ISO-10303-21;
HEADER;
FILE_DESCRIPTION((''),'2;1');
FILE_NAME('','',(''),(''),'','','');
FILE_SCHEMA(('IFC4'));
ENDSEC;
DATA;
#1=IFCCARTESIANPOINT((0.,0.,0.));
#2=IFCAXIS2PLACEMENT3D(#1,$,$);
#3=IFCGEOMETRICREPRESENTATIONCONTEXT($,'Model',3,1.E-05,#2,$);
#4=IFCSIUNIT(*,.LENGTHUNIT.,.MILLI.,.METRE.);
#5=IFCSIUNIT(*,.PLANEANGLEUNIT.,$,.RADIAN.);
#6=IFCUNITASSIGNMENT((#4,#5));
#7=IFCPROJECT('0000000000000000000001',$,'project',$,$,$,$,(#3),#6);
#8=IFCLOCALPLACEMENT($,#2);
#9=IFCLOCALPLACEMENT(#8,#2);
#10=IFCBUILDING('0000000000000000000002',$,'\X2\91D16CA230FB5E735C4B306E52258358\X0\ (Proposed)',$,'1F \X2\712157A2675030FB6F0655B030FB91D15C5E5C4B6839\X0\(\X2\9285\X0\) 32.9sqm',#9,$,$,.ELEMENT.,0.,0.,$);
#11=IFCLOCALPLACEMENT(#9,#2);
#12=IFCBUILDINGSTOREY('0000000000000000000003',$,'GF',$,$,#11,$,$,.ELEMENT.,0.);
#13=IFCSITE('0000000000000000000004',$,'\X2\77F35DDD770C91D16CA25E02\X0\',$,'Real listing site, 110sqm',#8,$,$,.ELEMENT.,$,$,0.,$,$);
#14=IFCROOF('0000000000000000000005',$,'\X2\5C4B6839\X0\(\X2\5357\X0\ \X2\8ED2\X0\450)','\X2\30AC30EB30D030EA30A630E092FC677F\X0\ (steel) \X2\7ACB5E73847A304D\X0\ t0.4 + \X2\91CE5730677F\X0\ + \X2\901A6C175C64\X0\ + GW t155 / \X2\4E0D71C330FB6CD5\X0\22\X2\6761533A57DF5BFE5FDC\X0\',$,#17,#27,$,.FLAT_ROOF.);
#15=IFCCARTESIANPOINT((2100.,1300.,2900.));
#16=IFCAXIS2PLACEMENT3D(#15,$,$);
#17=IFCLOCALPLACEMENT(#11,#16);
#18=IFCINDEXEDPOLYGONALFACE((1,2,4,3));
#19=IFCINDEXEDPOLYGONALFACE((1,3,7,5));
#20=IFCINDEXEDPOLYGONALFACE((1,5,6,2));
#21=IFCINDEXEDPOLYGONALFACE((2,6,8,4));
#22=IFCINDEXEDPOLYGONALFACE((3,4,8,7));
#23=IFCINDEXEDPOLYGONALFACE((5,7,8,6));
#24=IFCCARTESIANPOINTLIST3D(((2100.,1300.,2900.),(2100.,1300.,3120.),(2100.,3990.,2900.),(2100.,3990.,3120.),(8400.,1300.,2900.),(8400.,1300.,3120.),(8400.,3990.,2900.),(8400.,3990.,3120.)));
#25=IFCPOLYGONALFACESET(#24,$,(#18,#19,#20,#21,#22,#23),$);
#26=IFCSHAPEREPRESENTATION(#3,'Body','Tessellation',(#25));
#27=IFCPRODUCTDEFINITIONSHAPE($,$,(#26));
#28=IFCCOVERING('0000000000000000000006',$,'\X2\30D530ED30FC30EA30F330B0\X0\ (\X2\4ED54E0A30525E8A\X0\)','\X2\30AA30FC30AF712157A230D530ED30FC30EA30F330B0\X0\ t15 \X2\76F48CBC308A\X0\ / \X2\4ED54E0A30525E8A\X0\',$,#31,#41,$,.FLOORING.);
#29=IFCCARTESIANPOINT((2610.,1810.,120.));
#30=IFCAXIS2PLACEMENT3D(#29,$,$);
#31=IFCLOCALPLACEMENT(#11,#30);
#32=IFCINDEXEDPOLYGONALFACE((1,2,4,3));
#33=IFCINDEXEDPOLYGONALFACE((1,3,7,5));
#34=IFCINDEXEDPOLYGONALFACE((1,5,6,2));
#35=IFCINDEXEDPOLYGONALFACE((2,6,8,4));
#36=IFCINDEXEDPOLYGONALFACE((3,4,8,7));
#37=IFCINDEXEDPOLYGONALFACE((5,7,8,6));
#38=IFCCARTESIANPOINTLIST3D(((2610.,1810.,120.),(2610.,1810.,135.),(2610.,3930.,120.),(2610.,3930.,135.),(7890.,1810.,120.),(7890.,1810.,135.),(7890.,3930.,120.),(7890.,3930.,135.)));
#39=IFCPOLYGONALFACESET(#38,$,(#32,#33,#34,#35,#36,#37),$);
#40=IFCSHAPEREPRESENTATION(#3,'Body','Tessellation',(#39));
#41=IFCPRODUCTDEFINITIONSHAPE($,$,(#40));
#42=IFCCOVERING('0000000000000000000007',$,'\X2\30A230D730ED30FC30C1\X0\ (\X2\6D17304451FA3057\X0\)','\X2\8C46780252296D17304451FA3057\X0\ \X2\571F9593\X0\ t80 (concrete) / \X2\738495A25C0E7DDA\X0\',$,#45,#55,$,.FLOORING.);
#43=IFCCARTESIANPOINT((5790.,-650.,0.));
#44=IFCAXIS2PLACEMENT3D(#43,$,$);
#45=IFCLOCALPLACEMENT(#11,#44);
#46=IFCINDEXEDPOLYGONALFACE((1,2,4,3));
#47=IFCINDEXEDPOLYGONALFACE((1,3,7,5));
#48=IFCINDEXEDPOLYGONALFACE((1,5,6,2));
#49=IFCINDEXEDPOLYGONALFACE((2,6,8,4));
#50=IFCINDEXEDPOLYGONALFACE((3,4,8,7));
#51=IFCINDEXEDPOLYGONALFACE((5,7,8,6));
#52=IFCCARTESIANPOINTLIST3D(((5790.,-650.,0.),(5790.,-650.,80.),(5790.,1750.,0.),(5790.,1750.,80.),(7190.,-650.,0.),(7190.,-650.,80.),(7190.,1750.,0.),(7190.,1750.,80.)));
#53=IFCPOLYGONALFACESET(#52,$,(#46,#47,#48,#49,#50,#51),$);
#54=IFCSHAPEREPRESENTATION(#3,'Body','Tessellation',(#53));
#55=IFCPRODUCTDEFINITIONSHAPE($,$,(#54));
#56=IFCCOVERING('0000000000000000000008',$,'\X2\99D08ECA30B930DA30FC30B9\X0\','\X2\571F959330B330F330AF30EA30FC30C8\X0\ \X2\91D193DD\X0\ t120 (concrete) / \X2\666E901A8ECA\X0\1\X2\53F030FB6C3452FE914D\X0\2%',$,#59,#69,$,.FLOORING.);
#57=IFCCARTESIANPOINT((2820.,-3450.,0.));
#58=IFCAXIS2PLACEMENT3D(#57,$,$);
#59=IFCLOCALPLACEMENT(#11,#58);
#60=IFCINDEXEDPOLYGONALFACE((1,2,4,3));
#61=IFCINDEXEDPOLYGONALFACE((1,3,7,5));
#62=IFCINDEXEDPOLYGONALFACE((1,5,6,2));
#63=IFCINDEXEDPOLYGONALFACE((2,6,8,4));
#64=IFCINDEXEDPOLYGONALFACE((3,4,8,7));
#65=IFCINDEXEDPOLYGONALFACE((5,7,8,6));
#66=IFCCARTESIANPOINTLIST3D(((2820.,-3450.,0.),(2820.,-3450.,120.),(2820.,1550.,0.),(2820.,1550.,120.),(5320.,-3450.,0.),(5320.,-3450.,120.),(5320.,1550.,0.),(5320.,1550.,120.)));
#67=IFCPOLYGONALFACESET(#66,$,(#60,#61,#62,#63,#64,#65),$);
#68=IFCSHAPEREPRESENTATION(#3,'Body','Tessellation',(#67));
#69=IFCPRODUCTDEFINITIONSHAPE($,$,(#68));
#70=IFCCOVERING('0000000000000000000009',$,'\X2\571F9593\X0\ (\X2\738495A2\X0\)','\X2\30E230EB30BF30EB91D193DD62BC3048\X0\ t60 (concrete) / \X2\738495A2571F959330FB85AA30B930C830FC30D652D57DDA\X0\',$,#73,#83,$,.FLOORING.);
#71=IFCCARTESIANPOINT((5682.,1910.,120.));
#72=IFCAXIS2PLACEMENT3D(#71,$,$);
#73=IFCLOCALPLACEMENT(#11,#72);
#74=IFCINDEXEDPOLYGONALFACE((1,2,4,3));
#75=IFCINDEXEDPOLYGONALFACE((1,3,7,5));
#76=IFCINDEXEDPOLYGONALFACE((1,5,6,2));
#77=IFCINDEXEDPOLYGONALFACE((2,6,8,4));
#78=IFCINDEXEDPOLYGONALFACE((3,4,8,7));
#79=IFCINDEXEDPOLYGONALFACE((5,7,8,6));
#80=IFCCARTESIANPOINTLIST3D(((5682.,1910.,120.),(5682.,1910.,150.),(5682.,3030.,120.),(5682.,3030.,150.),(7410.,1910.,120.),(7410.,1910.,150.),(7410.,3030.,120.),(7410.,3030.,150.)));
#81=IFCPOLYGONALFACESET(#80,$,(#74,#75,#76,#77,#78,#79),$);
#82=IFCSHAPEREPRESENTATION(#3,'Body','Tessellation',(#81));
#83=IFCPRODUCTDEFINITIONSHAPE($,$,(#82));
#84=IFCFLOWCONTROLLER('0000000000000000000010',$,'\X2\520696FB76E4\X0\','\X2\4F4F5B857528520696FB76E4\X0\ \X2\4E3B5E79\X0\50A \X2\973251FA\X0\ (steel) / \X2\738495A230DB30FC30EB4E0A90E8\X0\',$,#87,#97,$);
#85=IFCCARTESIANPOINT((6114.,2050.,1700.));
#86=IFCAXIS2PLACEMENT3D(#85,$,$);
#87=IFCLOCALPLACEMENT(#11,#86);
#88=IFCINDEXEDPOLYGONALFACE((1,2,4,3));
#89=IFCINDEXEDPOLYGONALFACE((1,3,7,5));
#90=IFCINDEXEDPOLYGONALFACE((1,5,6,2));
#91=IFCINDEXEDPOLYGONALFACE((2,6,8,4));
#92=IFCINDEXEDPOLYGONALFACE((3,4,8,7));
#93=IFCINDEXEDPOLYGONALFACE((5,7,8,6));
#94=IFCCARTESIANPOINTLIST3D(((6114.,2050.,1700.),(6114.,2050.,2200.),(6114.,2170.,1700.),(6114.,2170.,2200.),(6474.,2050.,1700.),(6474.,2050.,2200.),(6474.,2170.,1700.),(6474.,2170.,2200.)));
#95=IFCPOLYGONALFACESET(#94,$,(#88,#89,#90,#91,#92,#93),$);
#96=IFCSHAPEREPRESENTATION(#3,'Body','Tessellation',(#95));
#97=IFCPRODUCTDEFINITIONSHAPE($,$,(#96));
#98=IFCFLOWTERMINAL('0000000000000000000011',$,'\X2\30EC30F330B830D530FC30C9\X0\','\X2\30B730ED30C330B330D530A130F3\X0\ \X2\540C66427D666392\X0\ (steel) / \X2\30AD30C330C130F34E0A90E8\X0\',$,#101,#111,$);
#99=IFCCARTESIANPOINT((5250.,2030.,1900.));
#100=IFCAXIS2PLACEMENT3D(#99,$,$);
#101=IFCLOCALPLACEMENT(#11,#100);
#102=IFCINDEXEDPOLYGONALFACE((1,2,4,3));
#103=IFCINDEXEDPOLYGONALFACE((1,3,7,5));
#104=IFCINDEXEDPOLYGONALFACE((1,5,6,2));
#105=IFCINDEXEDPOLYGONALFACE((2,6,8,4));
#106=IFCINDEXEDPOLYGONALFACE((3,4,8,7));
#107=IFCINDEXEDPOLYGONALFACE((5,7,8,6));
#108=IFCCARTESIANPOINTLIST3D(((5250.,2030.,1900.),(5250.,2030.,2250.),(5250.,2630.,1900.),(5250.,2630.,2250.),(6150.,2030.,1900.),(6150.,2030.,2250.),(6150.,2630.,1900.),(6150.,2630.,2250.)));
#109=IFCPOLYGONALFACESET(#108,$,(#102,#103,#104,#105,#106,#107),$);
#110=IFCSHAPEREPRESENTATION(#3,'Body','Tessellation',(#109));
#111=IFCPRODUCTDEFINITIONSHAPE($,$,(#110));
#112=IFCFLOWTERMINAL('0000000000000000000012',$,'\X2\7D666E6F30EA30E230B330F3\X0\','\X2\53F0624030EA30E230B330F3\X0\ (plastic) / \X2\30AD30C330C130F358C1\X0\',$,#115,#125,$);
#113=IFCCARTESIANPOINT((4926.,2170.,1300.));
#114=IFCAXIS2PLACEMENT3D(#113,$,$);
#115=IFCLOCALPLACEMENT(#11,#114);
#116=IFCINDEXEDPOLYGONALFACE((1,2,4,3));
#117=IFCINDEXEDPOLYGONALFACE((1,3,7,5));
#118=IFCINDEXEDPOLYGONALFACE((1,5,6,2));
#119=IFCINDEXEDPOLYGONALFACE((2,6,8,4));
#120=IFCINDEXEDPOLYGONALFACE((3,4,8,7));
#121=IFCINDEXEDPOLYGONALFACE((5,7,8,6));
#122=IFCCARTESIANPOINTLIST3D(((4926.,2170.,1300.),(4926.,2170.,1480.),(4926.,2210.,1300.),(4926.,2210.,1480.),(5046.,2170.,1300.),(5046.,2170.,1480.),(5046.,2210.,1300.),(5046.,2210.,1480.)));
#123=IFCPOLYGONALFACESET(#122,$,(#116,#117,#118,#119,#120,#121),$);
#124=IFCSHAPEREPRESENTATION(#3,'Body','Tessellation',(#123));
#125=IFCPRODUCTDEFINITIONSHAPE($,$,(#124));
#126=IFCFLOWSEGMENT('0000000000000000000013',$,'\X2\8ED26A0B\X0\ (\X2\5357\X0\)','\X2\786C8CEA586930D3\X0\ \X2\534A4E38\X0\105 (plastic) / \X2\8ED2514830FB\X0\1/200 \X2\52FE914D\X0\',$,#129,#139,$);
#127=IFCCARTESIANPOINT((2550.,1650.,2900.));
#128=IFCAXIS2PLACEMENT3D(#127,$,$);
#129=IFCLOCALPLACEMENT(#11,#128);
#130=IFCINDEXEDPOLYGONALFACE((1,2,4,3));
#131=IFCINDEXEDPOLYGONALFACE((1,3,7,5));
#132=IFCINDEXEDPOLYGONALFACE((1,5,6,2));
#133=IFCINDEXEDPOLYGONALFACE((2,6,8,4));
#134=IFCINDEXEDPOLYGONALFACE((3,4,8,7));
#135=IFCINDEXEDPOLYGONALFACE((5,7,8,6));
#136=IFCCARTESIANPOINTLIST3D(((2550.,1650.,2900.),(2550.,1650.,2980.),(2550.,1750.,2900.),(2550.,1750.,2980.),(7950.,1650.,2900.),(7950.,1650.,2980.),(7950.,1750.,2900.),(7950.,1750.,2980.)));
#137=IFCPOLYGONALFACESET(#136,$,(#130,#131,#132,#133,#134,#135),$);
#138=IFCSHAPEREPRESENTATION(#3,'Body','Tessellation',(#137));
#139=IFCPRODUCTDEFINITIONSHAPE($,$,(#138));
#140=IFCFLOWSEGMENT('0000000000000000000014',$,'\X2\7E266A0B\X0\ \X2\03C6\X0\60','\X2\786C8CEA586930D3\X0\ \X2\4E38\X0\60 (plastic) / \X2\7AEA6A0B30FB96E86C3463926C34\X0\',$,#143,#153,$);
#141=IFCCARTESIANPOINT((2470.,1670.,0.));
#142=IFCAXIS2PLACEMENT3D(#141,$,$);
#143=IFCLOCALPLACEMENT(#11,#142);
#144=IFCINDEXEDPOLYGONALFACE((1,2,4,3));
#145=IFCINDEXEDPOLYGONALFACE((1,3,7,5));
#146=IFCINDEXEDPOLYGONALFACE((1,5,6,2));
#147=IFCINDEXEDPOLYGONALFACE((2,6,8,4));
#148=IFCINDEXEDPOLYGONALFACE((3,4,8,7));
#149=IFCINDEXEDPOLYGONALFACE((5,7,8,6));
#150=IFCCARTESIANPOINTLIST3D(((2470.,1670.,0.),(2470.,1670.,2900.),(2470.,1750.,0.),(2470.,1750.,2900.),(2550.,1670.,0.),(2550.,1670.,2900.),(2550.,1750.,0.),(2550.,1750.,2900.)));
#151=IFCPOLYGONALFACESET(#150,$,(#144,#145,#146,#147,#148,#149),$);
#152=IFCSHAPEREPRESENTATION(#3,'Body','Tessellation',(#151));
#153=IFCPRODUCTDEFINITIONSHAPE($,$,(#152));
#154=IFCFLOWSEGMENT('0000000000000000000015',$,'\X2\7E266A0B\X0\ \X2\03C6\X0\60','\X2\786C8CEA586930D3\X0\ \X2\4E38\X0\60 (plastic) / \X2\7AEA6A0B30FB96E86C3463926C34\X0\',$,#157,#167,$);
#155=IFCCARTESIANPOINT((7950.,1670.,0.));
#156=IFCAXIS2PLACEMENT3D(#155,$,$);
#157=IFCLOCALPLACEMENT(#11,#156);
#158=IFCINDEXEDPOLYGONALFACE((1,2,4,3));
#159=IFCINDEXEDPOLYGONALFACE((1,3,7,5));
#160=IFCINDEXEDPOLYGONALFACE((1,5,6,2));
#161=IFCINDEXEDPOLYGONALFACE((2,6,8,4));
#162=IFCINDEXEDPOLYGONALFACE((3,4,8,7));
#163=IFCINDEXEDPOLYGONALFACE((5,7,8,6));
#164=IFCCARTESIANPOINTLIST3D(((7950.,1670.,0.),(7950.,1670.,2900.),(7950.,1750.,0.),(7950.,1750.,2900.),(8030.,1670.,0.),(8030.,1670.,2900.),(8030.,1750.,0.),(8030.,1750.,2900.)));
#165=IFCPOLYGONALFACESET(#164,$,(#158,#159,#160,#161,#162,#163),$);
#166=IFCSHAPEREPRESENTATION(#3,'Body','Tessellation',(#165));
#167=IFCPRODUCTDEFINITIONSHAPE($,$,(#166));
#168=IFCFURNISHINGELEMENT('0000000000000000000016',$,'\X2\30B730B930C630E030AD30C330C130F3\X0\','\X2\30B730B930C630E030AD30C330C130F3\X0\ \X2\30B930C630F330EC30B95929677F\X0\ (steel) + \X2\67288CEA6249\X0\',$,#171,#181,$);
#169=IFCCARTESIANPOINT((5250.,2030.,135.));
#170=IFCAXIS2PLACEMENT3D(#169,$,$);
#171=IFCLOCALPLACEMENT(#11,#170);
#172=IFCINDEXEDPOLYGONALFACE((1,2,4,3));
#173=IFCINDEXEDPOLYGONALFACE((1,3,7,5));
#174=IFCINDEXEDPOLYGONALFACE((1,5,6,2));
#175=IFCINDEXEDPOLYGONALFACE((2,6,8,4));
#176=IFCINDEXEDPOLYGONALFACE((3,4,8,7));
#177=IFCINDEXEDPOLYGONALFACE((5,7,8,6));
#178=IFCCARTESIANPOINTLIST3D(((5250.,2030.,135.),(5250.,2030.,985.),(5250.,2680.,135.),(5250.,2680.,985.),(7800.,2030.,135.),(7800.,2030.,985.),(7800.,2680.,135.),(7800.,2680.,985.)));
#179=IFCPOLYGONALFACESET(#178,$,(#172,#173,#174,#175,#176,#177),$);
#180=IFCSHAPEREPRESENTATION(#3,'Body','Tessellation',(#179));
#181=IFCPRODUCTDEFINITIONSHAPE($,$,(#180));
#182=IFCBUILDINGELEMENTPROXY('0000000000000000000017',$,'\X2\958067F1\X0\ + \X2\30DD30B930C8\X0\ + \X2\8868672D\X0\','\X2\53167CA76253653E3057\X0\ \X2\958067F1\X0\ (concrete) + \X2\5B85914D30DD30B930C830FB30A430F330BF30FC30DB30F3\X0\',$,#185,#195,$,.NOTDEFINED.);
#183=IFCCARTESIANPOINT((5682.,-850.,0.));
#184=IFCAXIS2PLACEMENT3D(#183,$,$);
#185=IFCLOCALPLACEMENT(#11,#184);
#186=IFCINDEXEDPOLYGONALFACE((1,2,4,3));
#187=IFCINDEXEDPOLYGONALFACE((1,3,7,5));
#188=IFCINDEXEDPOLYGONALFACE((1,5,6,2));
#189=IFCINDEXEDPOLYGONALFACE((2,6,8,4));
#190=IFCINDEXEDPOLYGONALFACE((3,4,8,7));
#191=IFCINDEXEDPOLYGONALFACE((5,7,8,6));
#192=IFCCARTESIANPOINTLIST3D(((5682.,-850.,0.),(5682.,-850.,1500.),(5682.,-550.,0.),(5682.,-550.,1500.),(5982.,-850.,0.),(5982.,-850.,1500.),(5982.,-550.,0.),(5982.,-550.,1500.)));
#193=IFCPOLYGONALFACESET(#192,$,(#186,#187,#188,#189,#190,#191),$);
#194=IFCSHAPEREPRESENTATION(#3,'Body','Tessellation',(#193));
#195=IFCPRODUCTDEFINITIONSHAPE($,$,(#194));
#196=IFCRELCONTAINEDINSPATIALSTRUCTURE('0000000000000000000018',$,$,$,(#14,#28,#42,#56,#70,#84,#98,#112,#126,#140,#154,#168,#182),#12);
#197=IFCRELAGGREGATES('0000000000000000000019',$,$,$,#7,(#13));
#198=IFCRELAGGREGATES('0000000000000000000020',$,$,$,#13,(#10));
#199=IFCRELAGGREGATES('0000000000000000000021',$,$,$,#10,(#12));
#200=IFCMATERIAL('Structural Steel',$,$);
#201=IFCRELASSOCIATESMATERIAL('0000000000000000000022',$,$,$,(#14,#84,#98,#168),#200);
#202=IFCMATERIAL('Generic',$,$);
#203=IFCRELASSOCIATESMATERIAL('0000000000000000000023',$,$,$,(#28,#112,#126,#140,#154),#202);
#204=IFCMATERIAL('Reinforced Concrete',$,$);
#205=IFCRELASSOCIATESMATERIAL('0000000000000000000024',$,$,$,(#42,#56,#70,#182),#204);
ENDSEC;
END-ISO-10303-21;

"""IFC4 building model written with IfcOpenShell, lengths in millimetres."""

from ifc_helpers import new_model, si_unit, frame, frame_2d, origin, place, context, project, spatial, rectangle, extrude, material, element, save


model = new_model("IFC4")

# Units and contexts
model_context = context("Model", 3, precision=1e-05, world=origin())
ifc_project = project(units=[si_unit("LENGTHUNIT", "METRE", prefix="MILLI"), si_unit("PLANEANGLEUNIT", "RADIAN")], contexts=[model_context])

# Site, building, storey
site_placement = place(None, origin())
site = spatial("IfcSite", under=ifc_project, at=site_placement, Name="石川県金沢市", ObjectType="Real listing site, 110sqm", CompositionType="ELEMENT", RefElevation=0.0)
building_placement = place(site_placement, origin())
building = spatial("IfcBuilding", under=site, at=building_placement, Name="金沢・平屋の別荘 (Proposed)", ObjectType="1F 無垢材・漆喰・金属屋根(銅) 32.9sqm", CompositionType="ELEMENT", ElevationOfRefHeight=0.0, ElevationOfTerrain=0.0)
storey_placement = place(building_placement, origin())
storey = spatial("IfcBuildingStorey", under=building, at=storey_placement, Name="GF", CompositionType="ELEMENT", Elevation=0.0)

# Shared definitions
ifc_material_1 = material(Name="Reinforced Concrete")

# Roof
ifc_material_2 = material(Name="Structural Steel")
roof_placement = place(storey_placement, frame((2100.0, 1300.0, 2900.0)))
element("IfcRoof", 1, at=roof_placement, inside=storey, material=ifc_material_2, Name="屋根(南 軒450)", Description="ガルバリウム鋼板 (steel) 立平葺き t0.4 + 野地板 + 通気層 + GW t155 / 不燃・法22条区域対応", PredefinedType="FLAT_ROOF", context=model_context, shape_type="SweptSolid", body=[
    extrude(rectangle(XDim=6300.0, YDim=2690.0, at=frame_2d((3150.0, 1345.0))), frame((2100.0, 1300.0, 2900.0)), (0.0, 0.0, 1.0), 220.0),
])

# Coverings
ifc_material_3 = material(Name="Generic")
covering_1_placement = place(storey_placement, frame((2610.0, 1810.0, 120.0)))
element("IfcCovering", 2, at=covering_1_placement, inside=storey, material=ifc_material_3, Name="フローリング (仕上げ床)", Description="オーク無垢フローリング t15 直貼り / 仕上げ床", PredefinedType="FLOORING", context=model_context, shape_type="SweptSolid", body=[
    extrude(rectangle(XDim=5280.0, YDim=2120.0, at=frame_2d((2640.0, 1060.0))), frame((2610.0, 1810.0, 120.0)), (0.0, 0.0, 1.0), 15.0),
])
covering_2_placement = place(storey_placement, frame((5790.0, -650.0, 0.0)))
element("IfcCovering", 3, at=covering_2_placement, inside=storey, material=ifc_material_1, Name="アプローチ (洗い出し)", Description="豆砂利洗い出し 土間 t80 (concrete) / 玄関導線", PredefinedType="FLOORING", context=model_context, shape_type="SweptSolid", body=[
    extrude(rectangle(XDim=1400.0, YDim=2400.0, at=frame_2d((700.0, 1200.0))), frame((5790.0, -650.0, 0.0)), (0.0, 0.0, 1.0), 80.0),
])
covering_3_placement = place(storey_placement, frame((2820.0, -3450.0, 0.0)))
element("IfcCovering", 4, at=covering_3_placement, inside=storey, material=ifc_material_1, Name="駐車スペース", Description="土間コンクリート 金鏝 t120 (concrete) / 普通車1台・水勾配2%", PredefinedType="FLOORING", context=model_context, shape_type="SweptSolid", body=[
    extrude(rectangle(XDim=2500.0, YDim=5000.0, at=frame_2d((1250.0, 2500.0))), frame((2820.0, -3450.0, 0.0)), (0.0, 0.0, 1.0), 120.0),
])
covering_4_placement = place(storey_placement, frame((5682.0, 1910.0, 120.0)))
element("IfcCovering", 5, at=covering_4_placement, inside=storey, material=ifc_material_1, Name="土間 (玄関)", Description="モルタル金鏝押え t60 (concrete) / 玄関土間・薪ストーブ動線", PredefinedType="FLOORING", context=model_context, shape_type="SweptSolid", body=[
    extrude(rectangle(XDim=1728.0, YDim=1120.0, at=frame_2d((864.0, 560.0))), frame((5682.0, 1910.0, 120.0)), (0.0, 0.0, 1.0), 30.0),
])

# Flow controller
flow_controller_placement = place(storey_placement, frame((6114.0, 2050.0, 1700.0)))
element("IfcFlowController", 6, at=flow_controller_placement, inside=storey, material=ifc_material_2, Name="分電盤", Description="住宅用分電盤 主幹50A 露出 (steel) / 玄関ホール上部", context=model_context, shape_type="SweptSolid", body=[
    extrude(rectangle(XDim=360.0, YDim=120.0, at=frame_2d((180.0, 60.0))), frame((6114.0, 2050.0, 1700.0)), (0.0, 0.0, 1.0), 500.0),
])

# Flow terminals
flow_terminal_1_placement = place(storey_placement, frame((5250.0, 2030.0, 1900.0)))
element("IfcFlowTerminal", 7, at=flow_terminal_1_placement, inside=storey, material=ifc_material_2, Name="レンジフード", Description="シロッコファン 同時給排 (steel) / キッチン上部", context=model_context, shape_type="SweptSolid", body=[
    extrude(rectangle(XDim=900.0, YDim=600.0, at=frame_2d((450.0, 300.0))), frame((5250.0, 2030.0, 1900.0)), (0.0, 0.0, 1.0), 350.0),
])
flow_terminal_2_placement = place(storey_placement, frame((4926.0, 2170.0, 1300.0)))
element("IfcFlowTerminal", 8, at=flow_terminal_2_placement, inside=storey, material=ifc_material_3, Name="給湯リモコン", Description="台所リモコン (plastic) / キッチン壁", context=model_context, shape_type="SweptSolid", body=[
    extrude(rectangle(XDim=120.0, YDim=40.0, at=frame_2d((60.0, 20.0))), frame((4926.0, 2170.0, 1300.0)), (0.0, 0.0, 1.0), 180.0),
])

# Flow segments
flow_segment_1_placement = place(storey_placement, frame((2550.0, 1650.0, 2900.0)))
element("IfcFlowSegment", 9, at=flow_segment_1_placement, inside=storey, material=ifc_material_3, Name="軒樋 (南)", Description="硬質塩ビ 半丸105 (plastic) / 軒先・1/200 勾配", context=model_context, shape_type="SweptSolid", body=[
    extrude(rectangle(XDim=5400.0, YDim=100.0, at=frame_2d((2700.0, 50.0))), frame((2550.0, 1650.0, 2900.0)), (0.0, 0.0, 1.0), 80.0),
])
flow_segment_2_placement = place(storey_placement, frame((2470.0, 1670.0, 0.0)))
element("IfcFlowSegment", 10, at=flow_segment_2_placement, inside=storey, material=ifc_material_3, Name="縦樋 φ60", Description="硬質塩ビ 丸60 (plastic) / 竪樋・雨水排水", context=model_context, shape_type="SweptSolid", body=[
    extrude(rectangle(XDim=80.0, YDim=80.0, at=frame_2d((40.0, 40.0))), frame((2470.0, 1670.0, 0.0)), (0.0, 0.0, 1.0), 2900.0),
])
flow_segment_3_placement = place(storey_placement, frame((7950.0, 1670.0, 0.0)))
element("IfcFlowSegment", 11, at=flow_segment_3_placement, inside=storey, material=ifc_material_3, Name="縦樋 φ60", Description="硬質塩ビ 丸60 (plastic) / 竪樋・雨水排水", context=model_context, shape_type="SweptSolid", body=[
    extrude(rectangle(XDim=80.0, YDim=80.0, at=frame_2d((40.0, 40.0))), frame((7950.0, 1670.0, 0.0)), (0.0, 0.0, 1.0), 2900.0),
])

# Furnishing element
furnishing_placement = place(storey_placement, frame((5250.0, 2030.0, 135.0)))
element("IfcFurnishingElement", 12, at=furnishing_placement, inside=storey, material=ifc_material_2, Name="システムキッチン", Description="システムキッチン ステンレス天板 (steel) + 木質扉", context=model_context, shape_type="SweptSolid", body=[
    extrude(rectangle(XDim=2550.0, YDim=650.0, at=frame_2d((1275.0, 325.0))), frame((5250.0, 2030.0, 135.0)), (0.0, 0.0, 1.0), 850.0),
])

# Building element proxy
proxy_placement = place(storey_placement, frame((5682.0, -850.0, 0.0)))
element("IfcBuildingElementProxy", 13, at=proxy_placement, inside=storey, material=ifc_material_1, Name="門柱 + ポスト + 表札", Description="化粧打放し 門柱 (concrete) + 宅配ポスト・インターホン", PredefinedType="NOTDEFINED", context=model_context, shape_type="SweptSolid", body=[
    extrude(rectangle(XDim=300.0, YDim=300.0, at=frame_2d((150.0, 150.0))), frame((5682.0, -850.0, 0.0)), (0.0, 0.0, 1.0), 1500.0),
])

save(model, "model.ifc")
